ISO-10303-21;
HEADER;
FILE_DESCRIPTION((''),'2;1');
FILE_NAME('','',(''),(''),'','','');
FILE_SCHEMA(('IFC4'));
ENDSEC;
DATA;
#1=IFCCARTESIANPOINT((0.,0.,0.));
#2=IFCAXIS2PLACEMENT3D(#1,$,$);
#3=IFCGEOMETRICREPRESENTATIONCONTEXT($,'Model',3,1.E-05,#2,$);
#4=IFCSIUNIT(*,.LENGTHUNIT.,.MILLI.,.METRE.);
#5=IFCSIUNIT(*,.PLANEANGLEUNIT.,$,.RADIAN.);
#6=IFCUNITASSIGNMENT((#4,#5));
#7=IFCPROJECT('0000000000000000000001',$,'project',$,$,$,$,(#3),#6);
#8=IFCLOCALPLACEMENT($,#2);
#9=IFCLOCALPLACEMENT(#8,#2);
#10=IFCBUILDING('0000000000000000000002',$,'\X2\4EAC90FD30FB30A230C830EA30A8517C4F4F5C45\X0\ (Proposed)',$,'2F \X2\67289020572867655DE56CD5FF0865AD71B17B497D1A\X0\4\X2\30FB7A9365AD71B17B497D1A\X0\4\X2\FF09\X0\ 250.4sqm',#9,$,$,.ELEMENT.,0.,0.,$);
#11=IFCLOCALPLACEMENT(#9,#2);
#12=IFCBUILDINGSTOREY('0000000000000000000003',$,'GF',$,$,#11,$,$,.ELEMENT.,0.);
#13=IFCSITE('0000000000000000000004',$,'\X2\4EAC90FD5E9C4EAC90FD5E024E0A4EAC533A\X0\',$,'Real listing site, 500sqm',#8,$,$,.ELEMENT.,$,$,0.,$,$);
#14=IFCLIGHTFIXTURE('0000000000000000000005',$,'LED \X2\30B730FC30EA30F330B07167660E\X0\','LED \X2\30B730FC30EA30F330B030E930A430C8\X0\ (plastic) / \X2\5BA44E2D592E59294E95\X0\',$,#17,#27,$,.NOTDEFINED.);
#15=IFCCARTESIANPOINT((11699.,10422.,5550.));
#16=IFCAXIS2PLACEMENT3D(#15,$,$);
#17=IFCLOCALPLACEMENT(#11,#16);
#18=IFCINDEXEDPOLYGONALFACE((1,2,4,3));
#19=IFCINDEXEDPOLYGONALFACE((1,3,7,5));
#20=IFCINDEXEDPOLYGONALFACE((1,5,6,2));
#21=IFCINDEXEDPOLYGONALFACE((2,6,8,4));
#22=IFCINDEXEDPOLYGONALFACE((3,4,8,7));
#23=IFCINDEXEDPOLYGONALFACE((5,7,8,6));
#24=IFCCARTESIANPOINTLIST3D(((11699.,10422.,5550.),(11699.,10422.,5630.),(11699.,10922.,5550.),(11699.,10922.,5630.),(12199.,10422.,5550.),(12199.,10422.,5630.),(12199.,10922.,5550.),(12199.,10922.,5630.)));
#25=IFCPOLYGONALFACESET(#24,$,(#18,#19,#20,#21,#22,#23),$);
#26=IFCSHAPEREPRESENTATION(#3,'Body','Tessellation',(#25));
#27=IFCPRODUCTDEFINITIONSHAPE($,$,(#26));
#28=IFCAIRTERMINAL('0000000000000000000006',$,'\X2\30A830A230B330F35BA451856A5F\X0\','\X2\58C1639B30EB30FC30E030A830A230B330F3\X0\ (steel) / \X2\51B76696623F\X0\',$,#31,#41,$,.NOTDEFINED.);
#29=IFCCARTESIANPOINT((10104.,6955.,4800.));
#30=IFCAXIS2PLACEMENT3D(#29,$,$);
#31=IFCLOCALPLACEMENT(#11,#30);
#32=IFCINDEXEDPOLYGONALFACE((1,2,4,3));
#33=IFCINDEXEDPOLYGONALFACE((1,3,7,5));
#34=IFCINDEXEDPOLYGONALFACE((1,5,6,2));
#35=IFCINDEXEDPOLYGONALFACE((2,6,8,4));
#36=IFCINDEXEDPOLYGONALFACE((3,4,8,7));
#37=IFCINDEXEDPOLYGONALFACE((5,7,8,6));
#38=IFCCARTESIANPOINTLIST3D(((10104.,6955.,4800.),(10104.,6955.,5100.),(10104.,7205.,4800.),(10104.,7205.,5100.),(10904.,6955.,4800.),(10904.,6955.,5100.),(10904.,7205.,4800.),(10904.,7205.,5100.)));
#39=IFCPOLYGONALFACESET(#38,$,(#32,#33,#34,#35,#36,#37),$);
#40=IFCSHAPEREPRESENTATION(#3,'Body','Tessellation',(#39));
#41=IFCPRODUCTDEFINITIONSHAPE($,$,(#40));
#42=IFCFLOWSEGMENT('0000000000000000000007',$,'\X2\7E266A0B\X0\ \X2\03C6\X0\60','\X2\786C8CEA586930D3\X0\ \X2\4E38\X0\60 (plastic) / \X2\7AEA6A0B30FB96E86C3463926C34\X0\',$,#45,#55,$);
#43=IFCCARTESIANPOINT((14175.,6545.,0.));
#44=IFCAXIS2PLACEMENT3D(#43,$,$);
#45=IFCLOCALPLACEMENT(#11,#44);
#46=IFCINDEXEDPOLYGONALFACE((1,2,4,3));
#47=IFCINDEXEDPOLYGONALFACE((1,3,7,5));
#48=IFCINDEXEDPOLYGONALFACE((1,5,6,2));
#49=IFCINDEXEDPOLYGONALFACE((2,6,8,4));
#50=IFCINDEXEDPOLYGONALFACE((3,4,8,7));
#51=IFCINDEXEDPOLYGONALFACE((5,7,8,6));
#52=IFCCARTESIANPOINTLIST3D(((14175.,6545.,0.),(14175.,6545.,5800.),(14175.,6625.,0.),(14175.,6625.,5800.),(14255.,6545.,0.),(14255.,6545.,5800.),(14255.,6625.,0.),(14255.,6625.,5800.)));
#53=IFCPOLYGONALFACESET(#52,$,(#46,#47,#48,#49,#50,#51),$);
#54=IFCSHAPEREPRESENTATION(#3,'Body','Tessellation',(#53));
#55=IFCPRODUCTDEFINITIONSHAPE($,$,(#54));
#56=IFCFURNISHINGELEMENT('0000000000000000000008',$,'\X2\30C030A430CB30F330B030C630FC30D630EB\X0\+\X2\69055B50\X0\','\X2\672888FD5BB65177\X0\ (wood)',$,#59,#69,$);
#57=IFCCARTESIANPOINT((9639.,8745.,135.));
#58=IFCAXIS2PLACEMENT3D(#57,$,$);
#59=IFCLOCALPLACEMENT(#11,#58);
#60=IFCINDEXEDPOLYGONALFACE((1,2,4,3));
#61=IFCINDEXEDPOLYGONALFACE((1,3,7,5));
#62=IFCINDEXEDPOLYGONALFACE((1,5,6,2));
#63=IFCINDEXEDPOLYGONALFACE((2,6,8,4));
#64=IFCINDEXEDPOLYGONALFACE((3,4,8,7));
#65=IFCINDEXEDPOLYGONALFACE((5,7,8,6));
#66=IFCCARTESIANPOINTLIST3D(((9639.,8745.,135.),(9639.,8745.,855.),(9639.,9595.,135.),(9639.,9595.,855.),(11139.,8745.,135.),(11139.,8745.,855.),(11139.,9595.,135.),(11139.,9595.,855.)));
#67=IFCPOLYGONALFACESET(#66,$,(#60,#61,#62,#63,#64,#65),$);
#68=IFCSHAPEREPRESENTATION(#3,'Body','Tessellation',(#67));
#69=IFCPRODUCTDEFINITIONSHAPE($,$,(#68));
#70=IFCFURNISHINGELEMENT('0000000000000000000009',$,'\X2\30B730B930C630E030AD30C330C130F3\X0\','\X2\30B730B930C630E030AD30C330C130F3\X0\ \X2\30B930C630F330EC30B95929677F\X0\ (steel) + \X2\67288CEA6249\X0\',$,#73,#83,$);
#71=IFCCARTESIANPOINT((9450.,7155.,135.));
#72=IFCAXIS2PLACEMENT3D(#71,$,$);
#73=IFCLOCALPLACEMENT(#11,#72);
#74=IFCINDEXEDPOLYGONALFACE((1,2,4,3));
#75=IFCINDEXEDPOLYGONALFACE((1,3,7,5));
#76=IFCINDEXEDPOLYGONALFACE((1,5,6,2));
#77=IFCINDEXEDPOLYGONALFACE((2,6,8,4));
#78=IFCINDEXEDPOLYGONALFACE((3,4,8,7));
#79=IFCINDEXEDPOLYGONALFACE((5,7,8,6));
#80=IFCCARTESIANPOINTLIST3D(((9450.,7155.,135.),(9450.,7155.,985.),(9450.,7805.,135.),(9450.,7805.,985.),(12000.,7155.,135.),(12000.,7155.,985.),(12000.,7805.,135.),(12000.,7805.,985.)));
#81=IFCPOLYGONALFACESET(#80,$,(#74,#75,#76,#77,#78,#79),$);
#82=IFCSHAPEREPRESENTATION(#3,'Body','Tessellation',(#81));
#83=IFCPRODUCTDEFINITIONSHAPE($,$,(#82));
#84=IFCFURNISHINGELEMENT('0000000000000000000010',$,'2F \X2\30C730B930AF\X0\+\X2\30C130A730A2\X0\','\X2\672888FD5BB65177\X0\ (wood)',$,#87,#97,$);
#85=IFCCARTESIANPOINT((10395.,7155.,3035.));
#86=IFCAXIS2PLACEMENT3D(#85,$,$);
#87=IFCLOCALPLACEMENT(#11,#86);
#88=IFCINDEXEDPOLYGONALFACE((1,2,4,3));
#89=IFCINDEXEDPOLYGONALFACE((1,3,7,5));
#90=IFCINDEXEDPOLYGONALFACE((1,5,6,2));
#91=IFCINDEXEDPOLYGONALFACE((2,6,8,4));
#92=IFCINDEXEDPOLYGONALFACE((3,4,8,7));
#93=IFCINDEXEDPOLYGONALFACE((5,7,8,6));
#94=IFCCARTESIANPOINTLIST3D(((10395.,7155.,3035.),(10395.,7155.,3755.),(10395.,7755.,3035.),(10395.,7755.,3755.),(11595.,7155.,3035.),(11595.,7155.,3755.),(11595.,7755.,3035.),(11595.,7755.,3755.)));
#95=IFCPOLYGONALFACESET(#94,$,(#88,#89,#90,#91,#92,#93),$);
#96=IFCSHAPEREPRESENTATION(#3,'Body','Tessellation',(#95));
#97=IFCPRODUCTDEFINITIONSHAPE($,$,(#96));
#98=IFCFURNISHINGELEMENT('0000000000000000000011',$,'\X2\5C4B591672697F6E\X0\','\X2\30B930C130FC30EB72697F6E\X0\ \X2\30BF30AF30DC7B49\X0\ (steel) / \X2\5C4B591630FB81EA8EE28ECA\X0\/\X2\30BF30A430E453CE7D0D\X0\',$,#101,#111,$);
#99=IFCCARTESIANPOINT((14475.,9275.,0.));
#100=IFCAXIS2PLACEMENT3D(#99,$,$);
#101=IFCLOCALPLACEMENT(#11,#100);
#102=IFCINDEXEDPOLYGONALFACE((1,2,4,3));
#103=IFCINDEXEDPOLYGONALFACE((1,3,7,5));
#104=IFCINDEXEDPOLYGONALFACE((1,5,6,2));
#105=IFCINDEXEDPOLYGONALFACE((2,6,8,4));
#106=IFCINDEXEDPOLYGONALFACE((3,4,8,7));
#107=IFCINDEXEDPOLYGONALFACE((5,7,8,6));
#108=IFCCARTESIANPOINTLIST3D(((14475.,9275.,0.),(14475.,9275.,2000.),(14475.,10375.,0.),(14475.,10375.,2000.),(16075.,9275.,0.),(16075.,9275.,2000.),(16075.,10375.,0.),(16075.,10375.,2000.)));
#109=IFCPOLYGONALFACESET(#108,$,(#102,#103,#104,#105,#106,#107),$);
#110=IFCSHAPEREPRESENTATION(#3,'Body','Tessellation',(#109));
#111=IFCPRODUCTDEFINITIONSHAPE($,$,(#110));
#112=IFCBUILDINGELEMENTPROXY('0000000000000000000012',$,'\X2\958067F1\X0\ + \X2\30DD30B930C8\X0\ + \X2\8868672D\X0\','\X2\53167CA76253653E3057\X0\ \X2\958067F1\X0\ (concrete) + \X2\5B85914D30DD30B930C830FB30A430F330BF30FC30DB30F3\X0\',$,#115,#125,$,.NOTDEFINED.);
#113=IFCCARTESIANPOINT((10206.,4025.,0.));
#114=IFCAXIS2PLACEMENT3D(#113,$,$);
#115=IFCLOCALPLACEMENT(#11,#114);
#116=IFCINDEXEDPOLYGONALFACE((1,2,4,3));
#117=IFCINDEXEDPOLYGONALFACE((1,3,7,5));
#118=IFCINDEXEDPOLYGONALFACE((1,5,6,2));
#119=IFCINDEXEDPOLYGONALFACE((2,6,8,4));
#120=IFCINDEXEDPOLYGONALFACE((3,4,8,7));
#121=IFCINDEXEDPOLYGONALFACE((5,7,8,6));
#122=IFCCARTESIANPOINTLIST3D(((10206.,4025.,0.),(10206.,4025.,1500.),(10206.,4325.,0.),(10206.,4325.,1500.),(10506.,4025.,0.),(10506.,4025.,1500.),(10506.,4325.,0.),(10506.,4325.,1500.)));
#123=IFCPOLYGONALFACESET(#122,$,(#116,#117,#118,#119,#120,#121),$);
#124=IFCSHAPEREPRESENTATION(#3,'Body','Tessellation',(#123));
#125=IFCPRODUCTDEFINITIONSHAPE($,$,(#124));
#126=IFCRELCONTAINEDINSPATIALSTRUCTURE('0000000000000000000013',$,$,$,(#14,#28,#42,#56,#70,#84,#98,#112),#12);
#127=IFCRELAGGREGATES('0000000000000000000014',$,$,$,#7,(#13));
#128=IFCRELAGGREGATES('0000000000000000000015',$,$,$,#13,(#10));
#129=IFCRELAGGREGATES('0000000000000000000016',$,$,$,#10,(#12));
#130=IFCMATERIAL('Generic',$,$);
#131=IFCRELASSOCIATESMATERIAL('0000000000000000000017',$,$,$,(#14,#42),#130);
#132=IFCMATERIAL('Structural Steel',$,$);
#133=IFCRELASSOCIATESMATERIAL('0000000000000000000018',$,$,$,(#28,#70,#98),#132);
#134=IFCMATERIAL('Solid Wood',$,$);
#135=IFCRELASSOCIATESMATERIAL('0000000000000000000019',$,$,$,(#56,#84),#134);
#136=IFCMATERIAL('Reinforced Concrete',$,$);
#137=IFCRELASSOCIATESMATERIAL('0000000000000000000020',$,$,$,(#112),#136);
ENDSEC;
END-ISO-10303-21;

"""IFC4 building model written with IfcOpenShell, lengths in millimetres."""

from ifc_helpers import new_model, si_unit, frame, frame_2d, origin, place, context, project, spatial, rectangle, extrude, material, element, save


model = new_model("IFC4")

# Units and contexts
model_context = context("Model", 3, precision=1e-05, world=origin())
ifc_project = project(units=[si_unit("LENGTHUNIT", "METRE", prefix="MILLI"), si_unit("PLANEANGLEUNIT", "RADIAN")], contexts=[model_context])

# Site, building, storey
site_placement = place(None, origin())
site = spatial("IfcSite", under=ifc_project, at=site_placement, Name="京都府京都市上京区", ObjectType="Real listing site, 500sqm", CompositionType="ELEMENT", RefElevation=0.0)
building_placement = place(site_placement, origin())
building = spatial("IfcBuilding", under=site, at=building_placement, Name="京都・アトリエ兼住居 (Proposed)", ObjectType="2F 木造在来工法（断熱等級4・窓断熱等級4） 250.4sqm", CompositionType="ELEMENT", ElevationOfRefHeight=0.0, ElevationOfTerrain=0.0)
storey_placement = place(building_placement, origin())
storey = spatial("IfcBuildingStorey", under=building, at=storey_placement, Name="GF", CompositionType="ELEMENT", Elevation=0.0)

# Shared definitions
ifc_material_1 = material(Name="Solid Wood")

# Shared definitions
ifc_material_2 = material(Name="Reinforced Concrete")

# Shared definitions
ifc_material_3 = material(Name="Structural Steel")

# Shared definitions
ifc_material_4 = material(Name="Generic")

# Light fixture
light_fixture_placement = place(storey_placement, frame((11699.0, 10422.0, 5550.0)))
element("IfcLightFixture", 1, at=light_fixture_placement, inside=storey, material=ifc_material_4, Name="LED シーリング照明", Description="LED シーリングライト (plastic) / 室中央天井", PredefinedType="NOTDEFINED", context=model_context, shape_type="SweptSolid", body=[
    extrude(rectangle(XDim=500.0, YDim=500.0, at=frame_2d((250.0, 250.0))), frame((11699.0, 10422.0, 5550.0)), (0.0, 0.0, 1.0), 80.0),
])

# Air terminal
air_terminal_placement = place(storey_placement, frame((10104.0, 6955.0, 4800.0)))
element("IfcAirTerminal", 2, at=air_terminal_placement, inside=storey, material=ifc_material_3, Name="エアコン室内機", Description="壁掛ルームエアコン (steel) / 冷暖房", PredefinedType="NOTDEFINED", context=model_context, shape_type="SweptSolid", body=[
    extrude(rectangle(XDim=800.0, YDim=250.0, at=frame_2d((400.0, 125.0))), frame((10104.0, 6955.0, 4800.0)), (0.0, 0.0, 1.0), 300.0),
])

# Flow segment
flow_segment_placement = place(storey_placement, frame((14175.0, 6545.0, 0.0)))
element("IfcFlowSegment", 3, at=flow_segment_placement, inside=storey, material=ifc_material_4, Name="縦樋 φ60", Description="硬質塩ビ 丸60 (plastic) / 竪樋・雨水排水", context=model_context, shape_type="SweptSolid", body=[
    extrude(rectangle(XDim=80.0, YDim=80.0, at=frame_2d((40.0, 40.0))), frame((14175.0, 6545.0, 0.0)), (0.0, 0.0, 1.0), 5800.0),
])

# Furnishing elements
furnishing_1_placement = place(storey_placement, frame((9639.0, 8745.0, 135.0)))
element("IfcFurnishingElement", 4, at=furnishing_1_placement, inside=storey, material=ifc_material_1, Name="ダイニングテーブル+椅子", Description="木製家具 (wood)", context=model_context, shape_type="SweptSolid", body=[
    extrude(rectangle(XDim=1500.0, YDim=850.0, at=frame_2d((750.0, 425.0))), frame((9639.0, 8745.0, 135.0)), (0.0, 0.0, 1.0), 720.0),
])
furnishing_2_placement = place(storey_placement, frame((9450.0, 7155.0, 135.0)))
element("IfcFurnishingElement", 5, at=furnishing_2_placement, inside=storey, material=ifc_material_3, Name="システムキッチン", Description="システムキッチン ステンレス天板 (steel) + 木質扉", context=model_context, shape_type="SweptSolid", body=[
    extrude(rectangle(XDim=2550.0, YDim=650.0, at=frame_2d((1275.0, 325.0))), frame((9450.0, 7155.0, 135.0)), (0.0, 0.0, 1.0), 850.0),
])
furnishing_3_placement = place(storey_placement, frame((10395.0, 7155.0, 3035.0)))
element("IfcFurnishingElement", 6, at=furnishing_3_placement, inside=storey, material=ifc_material_1, Name="2F デスク+チェア", Description="木製家具 (wood)", context=model_context, shape_type="SweptSolid", body=[
    extrude(rectangle(XDim=1200.0, YDim=600.0, at=frame_2d((600.0, 300.0))), frame((10395.0, 7155.0, 3035.0)), (0.0, 0.0, 1.0), 720.0),
])
furnishing_4_placement = place(storey_placement, frame((14475.0, 9275.0, 0.0)))
element("IfcFurnishingElement", 7, at=furnishing_4_placement, inside=storey, material=ifc_material_3, Name="屋外物置", Description="スチール物置 タクボ等 (steel) / 屋外・自転車/タイヤ収納", context=model_context, shape_type="SweptSolid", body=[
    extrude(rectangle(XDim=1600.0, YDim=1100.0, at=frame_2d((800.0, 550.0))), frame((14475.0, 9275.0, 0.0)), (0.0, 0.0, 1.0), 2000.0),
])

# Building element proxy
proxy_placement = place(storey_placement, frame((10206.0, 4025.0, 0.0)))
element("IfcBuildingElementProxy", 8, at=proxy_placement, inside=storey, material=ifc_material_2, Name="門柱 + ポスト + 表札", Description="化粧打放し 門柱 (concrete) + 宅配ポスト・インターホン", PredefinedType="NOTDEFINED", context=model_context, shape_type="SweptSolid", body=[
    extrude(rectangle(XDim=300.0, YDim=300.0, at=frame_2d((150.0, 150.0))), frame((10206.0, 4025.0, 0.0)), (0.0, 0.0, 1.0), 1500.0),
])

save(model, "model.ifc")
